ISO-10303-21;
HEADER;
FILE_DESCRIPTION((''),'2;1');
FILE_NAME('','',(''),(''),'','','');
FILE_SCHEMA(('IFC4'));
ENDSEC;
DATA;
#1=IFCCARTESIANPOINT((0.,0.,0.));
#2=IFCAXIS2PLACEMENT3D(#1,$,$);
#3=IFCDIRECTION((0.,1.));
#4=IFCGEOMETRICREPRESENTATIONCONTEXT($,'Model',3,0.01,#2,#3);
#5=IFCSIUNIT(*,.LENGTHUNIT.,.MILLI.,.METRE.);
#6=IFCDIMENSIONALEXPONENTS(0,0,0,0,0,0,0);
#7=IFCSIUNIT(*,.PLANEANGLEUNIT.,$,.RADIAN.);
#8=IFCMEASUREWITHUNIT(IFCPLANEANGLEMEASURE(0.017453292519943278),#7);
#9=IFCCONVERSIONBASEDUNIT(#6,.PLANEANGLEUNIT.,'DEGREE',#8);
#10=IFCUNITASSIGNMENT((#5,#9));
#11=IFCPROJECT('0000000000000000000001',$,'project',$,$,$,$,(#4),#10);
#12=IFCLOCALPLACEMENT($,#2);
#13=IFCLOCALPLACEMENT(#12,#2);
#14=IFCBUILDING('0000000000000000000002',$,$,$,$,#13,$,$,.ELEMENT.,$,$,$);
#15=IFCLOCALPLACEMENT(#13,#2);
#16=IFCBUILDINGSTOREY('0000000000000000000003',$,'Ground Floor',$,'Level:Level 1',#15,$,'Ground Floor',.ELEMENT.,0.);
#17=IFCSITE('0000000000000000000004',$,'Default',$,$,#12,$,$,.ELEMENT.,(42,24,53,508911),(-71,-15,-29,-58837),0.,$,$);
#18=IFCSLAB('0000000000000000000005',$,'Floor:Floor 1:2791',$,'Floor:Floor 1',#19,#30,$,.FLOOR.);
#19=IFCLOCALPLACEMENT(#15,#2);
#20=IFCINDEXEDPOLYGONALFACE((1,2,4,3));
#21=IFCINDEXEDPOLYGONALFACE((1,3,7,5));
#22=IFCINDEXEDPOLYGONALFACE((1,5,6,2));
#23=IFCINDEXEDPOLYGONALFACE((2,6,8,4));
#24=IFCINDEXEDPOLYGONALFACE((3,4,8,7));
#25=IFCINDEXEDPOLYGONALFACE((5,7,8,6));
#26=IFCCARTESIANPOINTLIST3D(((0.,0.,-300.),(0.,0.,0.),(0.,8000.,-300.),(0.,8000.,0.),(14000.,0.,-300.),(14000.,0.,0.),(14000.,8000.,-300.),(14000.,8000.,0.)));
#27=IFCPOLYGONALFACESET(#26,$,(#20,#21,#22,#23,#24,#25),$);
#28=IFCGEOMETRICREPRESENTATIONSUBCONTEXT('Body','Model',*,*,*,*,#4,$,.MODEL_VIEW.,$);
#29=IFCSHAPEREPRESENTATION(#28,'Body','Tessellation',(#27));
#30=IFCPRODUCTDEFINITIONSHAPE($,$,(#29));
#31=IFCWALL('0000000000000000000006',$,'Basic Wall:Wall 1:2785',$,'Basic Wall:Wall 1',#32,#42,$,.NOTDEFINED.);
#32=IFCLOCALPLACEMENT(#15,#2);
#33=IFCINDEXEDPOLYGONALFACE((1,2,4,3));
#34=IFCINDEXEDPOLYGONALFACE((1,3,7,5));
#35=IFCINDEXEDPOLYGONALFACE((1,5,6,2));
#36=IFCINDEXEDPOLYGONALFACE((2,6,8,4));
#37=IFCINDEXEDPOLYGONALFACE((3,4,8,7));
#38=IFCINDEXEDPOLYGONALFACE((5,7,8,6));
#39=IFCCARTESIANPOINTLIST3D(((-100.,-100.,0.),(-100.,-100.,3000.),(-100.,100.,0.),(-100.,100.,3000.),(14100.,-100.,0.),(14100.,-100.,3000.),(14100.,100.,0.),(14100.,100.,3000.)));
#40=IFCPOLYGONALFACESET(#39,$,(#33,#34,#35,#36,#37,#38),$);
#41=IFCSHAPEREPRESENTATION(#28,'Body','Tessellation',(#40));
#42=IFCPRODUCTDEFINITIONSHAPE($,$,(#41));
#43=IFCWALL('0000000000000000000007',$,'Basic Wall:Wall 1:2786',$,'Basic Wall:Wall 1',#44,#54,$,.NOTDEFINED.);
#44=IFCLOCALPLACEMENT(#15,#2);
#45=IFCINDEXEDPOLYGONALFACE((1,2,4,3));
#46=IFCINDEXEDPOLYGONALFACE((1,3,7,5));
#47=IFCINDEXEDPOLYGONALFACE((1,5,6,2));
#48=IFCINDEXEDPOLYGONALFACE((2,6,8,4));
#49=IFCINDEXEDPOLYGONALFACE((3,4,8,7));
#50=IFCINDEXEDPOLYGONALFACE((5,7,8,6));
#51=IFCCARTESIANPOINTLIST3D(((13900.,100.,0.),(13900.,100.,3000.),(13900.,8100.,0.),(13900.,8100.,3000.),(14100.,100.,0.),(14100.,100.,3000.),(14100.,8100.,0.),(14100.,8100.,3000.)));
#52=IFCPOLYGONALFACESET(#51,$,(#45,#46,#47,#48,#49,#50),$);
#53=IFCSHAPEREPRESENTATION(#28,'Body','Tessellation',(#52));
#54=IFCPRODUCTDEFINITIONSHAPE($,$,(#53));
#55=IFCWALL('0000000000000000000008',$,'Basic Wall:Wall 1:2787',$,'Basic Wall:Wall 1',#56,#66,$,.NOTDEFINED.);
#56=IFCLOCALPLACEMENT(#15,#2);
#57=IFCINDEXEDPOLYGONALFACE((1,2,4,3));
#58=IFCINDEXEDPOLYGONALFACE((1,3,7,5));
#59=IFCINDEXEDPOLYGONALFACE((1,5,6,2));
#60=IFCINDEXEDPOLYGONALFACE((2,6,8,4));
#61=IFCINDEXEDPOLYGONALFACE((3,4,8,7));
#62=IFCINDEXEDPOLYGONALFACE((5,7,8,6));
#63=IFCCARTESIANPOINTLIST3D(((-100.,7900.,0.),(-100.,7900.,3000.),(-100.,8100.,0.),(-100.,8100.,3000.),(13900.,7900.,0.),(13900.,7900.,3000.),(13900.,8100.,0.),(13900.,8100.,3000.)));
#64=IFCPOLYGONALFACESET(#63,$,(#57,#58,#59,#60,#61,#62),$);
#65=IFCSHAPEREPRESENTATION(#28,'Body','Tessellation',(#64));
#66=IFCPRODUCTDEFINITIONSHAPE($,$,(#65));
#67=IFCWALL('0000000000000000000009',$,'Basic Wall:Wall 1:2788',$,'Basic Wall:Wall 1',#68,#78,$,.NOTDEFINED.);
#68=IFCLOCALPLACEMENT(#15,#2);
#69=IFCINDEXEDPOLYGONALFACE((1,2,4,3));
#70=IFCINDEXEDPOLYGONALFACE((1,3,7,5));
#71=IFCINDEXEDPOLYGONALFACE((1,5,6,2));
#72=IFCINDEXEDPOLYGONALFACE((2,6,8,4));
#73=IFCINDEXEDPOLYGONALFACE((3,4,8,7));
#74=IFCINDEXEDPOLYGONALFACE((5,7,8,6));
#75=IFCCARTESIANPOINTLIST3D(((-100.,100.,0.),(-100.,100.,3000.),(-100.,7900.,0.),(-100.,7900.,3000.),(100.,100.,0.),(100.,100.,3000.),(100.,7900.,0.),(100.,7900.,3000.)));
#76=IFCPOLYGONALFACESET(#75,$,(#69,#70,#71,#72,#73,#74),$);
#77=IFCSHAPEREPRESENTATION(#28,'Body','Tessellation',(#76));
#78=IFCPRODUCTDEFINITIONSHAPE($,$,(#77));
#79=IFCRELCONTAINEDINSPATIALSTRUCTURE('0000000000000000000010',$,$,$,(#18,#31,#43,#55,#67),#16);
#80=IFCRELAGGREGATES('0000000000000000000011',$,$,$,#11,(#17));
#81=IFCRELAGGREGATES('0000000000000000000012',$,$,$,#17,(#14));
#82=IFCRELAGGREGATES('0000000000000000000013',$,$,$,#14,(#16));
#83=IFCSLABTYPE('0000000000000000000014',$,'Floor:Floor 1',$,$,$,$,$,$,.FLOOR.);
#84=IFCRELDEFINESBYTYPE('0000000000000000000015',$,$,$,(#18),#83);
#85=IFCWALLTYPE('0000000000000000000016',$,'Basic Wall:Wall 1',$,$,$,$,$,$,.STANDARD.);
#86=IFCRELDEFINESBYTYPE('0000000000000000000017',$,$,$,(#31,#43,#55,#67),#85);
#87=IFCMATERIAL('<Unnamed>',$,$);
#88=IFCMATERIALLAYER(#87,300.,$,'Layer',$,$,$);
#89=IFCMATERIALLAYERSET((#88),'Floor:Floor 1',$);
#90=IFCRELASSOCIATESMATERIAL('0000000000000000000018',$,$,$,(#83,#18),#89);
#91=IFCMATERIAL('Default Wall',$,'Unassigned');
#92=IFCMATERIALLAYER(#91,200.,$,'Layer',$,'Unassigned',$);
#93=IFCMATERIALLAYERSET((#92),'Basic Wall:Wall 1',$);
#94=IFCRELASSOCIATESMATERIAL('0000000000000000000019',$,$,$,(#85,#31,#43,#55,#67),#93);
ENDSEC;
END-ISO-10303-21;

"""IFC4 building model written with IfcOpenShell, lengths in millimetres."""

from ifc_helpers import new_model, entity, si_unit, converted_unit, direction, frame, frame_2d, origin, origin_2d_with_axis, place, context, subcontext, project, spatial, rectangle, extrude, material, layer, layer_set, layer_usage, type_object, element, save


model = new_model("IFC4")

# Units and contexts
model_context = context("Model", 3, precision=0.01, world=origin(), true_north=direction((0.0, 1.0)))
body_context = subcontext(model_context, "Body", "Model", "MODEL_VIEW")
ifc_project = project(units=[si_unit("LENGTHUNIT", "METRE", prefix="MILLI"), converted_unit("PLANEANGLEUNIT", "DEGREE", entity("IfcPlaneAngleMeasure", 0.017453292519943278), si_unit("PLANEANGLEUNIT", "RADIAN"), dimensions=[0, 0, 0, 0, 0, 0, 0])], contexts=[model_context])

# Site, building, storey
site_placement = place(None, origin())
site = spatial("IfcSite", under=ifc_project, at=site_placement, Name="Default", CompositionType="ELEMENT", RefLatitude=(42, 24, 53, 508911), RefLongitude=(-71, -15, -29, -58837), RefElevation=0.0)
building_placement = place(site_placement, origin())
building = spatial("IfcBuilding", under=site, at=building_placement, CompositionType="ELEMENT")
storey_placement = place(building_placement, origin())
storey = spatial("IfcBuildingStorey", under=building, at=storey_placement, Name="Ground Floor", ObjectType="Level:Level 1", LongName="Ground Floor", CompositionType="ELEMENT", Elevation=0.0)

# Shared definitions
ifc_material_1 = material(Name="Default Wall", Category="Unassigned")

# Slab
ifc_material_2 = material(Name="<Unnamed>")
ifc_layer_1 = layer(ifc_material_2, 300.0, Name="Layer")
ifc_layer_set_1 = layer_set([ifc_layer_1], Name="Floor:Floor 1")
ifc_layer_usage_1 = layer_usage(ifc_layer_set_1, "AXIS3", "POSITIVE", 0.0)
slab_type = type_object("IfcSlabType", Name="Floor:Floor 1", PredefinedType="FLOOR", material=ifc_layer_set_1)
slab_placement = place(storey_placement, origin())
element("IfcSlab", 1, at=slab_placement, inside=storey, type_object=slab_type, material=ifc_layer_usage_1, Name="Floor:Floor 1:2791", ObjectType="Floor:Floor 1", PredefinedType="FLOOR", context=body_context, shape_type="SweptSolid", body=[
    extrude(rectangle(XDim=8000.0, YDim=14000.0, at=origin_2d_with_axis()), frame((7000.0, 4000.0, 0.0), z_axis=(0.0, 0.0, -1.0), x_axis=(0.0, 1.0, 0.0)), (0.0, 0.0, 1.0), 300.0),
])

# Walls
ifc_layer_2 = layer(ifc_material_1, 200.0, Name="Layer", Category="Unassigned")
ifc_layer_set_2 = layer_set([ifc_layer_2], Name="Basic Wall:Wall 1")
ifc_layer_usage_2 = layer_usage(ifc_layer_set_2, "AXIS2", "NEGATIVE", 100.0)
wall_type = type_object("IfcWallType", Name="Basic Wall:Wall 1", PredefinedType="STANDARD", material=ifc_layer_set_2)
wall_1_placement = place(storey_placement, frame((-100.0, 0.0, 0.0)))
element("IfcWall", 2, at=wall_1_placement, inside=storey, type_object=wall_type, material=ifc_layer_usage_2, Name="Basic Wall:Wall 1:2785", ObjectType="Basic Wall:Wall 1", PredefinedType="NOTDEFINED", context=body_context, shape_type="SweptSolid", body=[
    extrude(rectangle(XDim=14200.0, YDim=200.0, at=frame_2d((7100.0, 0.0), x_axis=(-1.0, 0.0))), origin(), (0.0, 0.0, 1.0), 3000.0),
])
ifc_layer_usage_3 = layer_usage(ifc_layer_set_2, "AXIS2", "NEGATIVE", 100.0)
wall_2_placement = place(storey_placement, frame((14000.0, 100.0, 0.0), z_axis=(0.0, 0.0, 1.0), x_axis=(0.0, 1.0, 0.0)))
element("IfcWall", 3, at=wall_2_placement, inside=storey, type_object=wall_type, material=ifc_layer_usage_3, Name="Basic Wall:Wall 1:2786", ObjectType="Basic Wall:Wall 1", PredefinedType="NOTDEFINED", context=body_context, shape_type="SweptSolid", body=[
    extrude(rectangle(XDim=8000.0, YDim=200.0, at=frame_2d((4000.0, 0.0), x_axis=(-1.0, 0.0))), origin(), (0.0, 0.0, 1.0), 3000.0),
])
ifc_layer_usage_4 = layer_usage(ifc_layer_set_2, "AXIS2", "NEGATIVE", 100.0)
wall_3_placement = place(storey_placement, frame((13900.0, 8000.0, 0.0), z_axis=(0.0, 0.0, 1.0), x_axis=(-1.0, 0.0, 0.0)))
element("IfcWall", 4, at=wall_3_placement, inside=storey, type_object=wall_type, material=ifc_layer_usage_4, Name="Basic Wall:Wall 1:2787", ObjectType="Basic Wall:Wall 1", PredefinedType="NOTDEFINED", context=body_context, shape_type="SweptSolid", body=[
    extrude(rectangle(XDim=14000.0, YDim=200.0, at=frame_2d((7000.0, 0.0), x_axis=(-1.0, 0.0))), origin(), (0.0, 0.0, 1.0), 3000.0),
])
ifc_layer_usage_5 = layer_usage(ifc_layer_set_2, "AXIS2", "NEGATIVE", 100.0)
wall_4_placement = place(storey_placement, frame((0.0, 7900.0, 0.0), z_axis=(0.0, 0.0, 1.0), x_axis=(0.0, -1.0, 0.0)))
element("IfcWall", 5, at=wall_4_placement, inside=storey, type_object=wall_type, material=ifc_layer_usage_5, Name="Basic Wall:Wall 1:2788", ObjectType="Basic Wall:Wall 1", PredefinedType="NOTDEFINED", context=body_context, shape_type="SweptSolid", body=[
    extrude(rectangle(XDim=7800.0, YDim=200.0, at=frame_2d((3900.0, 0.0), x_axis=(-1.0, 0.0))), origin(), (0.0, 0.0, 1.0), 3000.0),
])

save(model, "model.ifc")
